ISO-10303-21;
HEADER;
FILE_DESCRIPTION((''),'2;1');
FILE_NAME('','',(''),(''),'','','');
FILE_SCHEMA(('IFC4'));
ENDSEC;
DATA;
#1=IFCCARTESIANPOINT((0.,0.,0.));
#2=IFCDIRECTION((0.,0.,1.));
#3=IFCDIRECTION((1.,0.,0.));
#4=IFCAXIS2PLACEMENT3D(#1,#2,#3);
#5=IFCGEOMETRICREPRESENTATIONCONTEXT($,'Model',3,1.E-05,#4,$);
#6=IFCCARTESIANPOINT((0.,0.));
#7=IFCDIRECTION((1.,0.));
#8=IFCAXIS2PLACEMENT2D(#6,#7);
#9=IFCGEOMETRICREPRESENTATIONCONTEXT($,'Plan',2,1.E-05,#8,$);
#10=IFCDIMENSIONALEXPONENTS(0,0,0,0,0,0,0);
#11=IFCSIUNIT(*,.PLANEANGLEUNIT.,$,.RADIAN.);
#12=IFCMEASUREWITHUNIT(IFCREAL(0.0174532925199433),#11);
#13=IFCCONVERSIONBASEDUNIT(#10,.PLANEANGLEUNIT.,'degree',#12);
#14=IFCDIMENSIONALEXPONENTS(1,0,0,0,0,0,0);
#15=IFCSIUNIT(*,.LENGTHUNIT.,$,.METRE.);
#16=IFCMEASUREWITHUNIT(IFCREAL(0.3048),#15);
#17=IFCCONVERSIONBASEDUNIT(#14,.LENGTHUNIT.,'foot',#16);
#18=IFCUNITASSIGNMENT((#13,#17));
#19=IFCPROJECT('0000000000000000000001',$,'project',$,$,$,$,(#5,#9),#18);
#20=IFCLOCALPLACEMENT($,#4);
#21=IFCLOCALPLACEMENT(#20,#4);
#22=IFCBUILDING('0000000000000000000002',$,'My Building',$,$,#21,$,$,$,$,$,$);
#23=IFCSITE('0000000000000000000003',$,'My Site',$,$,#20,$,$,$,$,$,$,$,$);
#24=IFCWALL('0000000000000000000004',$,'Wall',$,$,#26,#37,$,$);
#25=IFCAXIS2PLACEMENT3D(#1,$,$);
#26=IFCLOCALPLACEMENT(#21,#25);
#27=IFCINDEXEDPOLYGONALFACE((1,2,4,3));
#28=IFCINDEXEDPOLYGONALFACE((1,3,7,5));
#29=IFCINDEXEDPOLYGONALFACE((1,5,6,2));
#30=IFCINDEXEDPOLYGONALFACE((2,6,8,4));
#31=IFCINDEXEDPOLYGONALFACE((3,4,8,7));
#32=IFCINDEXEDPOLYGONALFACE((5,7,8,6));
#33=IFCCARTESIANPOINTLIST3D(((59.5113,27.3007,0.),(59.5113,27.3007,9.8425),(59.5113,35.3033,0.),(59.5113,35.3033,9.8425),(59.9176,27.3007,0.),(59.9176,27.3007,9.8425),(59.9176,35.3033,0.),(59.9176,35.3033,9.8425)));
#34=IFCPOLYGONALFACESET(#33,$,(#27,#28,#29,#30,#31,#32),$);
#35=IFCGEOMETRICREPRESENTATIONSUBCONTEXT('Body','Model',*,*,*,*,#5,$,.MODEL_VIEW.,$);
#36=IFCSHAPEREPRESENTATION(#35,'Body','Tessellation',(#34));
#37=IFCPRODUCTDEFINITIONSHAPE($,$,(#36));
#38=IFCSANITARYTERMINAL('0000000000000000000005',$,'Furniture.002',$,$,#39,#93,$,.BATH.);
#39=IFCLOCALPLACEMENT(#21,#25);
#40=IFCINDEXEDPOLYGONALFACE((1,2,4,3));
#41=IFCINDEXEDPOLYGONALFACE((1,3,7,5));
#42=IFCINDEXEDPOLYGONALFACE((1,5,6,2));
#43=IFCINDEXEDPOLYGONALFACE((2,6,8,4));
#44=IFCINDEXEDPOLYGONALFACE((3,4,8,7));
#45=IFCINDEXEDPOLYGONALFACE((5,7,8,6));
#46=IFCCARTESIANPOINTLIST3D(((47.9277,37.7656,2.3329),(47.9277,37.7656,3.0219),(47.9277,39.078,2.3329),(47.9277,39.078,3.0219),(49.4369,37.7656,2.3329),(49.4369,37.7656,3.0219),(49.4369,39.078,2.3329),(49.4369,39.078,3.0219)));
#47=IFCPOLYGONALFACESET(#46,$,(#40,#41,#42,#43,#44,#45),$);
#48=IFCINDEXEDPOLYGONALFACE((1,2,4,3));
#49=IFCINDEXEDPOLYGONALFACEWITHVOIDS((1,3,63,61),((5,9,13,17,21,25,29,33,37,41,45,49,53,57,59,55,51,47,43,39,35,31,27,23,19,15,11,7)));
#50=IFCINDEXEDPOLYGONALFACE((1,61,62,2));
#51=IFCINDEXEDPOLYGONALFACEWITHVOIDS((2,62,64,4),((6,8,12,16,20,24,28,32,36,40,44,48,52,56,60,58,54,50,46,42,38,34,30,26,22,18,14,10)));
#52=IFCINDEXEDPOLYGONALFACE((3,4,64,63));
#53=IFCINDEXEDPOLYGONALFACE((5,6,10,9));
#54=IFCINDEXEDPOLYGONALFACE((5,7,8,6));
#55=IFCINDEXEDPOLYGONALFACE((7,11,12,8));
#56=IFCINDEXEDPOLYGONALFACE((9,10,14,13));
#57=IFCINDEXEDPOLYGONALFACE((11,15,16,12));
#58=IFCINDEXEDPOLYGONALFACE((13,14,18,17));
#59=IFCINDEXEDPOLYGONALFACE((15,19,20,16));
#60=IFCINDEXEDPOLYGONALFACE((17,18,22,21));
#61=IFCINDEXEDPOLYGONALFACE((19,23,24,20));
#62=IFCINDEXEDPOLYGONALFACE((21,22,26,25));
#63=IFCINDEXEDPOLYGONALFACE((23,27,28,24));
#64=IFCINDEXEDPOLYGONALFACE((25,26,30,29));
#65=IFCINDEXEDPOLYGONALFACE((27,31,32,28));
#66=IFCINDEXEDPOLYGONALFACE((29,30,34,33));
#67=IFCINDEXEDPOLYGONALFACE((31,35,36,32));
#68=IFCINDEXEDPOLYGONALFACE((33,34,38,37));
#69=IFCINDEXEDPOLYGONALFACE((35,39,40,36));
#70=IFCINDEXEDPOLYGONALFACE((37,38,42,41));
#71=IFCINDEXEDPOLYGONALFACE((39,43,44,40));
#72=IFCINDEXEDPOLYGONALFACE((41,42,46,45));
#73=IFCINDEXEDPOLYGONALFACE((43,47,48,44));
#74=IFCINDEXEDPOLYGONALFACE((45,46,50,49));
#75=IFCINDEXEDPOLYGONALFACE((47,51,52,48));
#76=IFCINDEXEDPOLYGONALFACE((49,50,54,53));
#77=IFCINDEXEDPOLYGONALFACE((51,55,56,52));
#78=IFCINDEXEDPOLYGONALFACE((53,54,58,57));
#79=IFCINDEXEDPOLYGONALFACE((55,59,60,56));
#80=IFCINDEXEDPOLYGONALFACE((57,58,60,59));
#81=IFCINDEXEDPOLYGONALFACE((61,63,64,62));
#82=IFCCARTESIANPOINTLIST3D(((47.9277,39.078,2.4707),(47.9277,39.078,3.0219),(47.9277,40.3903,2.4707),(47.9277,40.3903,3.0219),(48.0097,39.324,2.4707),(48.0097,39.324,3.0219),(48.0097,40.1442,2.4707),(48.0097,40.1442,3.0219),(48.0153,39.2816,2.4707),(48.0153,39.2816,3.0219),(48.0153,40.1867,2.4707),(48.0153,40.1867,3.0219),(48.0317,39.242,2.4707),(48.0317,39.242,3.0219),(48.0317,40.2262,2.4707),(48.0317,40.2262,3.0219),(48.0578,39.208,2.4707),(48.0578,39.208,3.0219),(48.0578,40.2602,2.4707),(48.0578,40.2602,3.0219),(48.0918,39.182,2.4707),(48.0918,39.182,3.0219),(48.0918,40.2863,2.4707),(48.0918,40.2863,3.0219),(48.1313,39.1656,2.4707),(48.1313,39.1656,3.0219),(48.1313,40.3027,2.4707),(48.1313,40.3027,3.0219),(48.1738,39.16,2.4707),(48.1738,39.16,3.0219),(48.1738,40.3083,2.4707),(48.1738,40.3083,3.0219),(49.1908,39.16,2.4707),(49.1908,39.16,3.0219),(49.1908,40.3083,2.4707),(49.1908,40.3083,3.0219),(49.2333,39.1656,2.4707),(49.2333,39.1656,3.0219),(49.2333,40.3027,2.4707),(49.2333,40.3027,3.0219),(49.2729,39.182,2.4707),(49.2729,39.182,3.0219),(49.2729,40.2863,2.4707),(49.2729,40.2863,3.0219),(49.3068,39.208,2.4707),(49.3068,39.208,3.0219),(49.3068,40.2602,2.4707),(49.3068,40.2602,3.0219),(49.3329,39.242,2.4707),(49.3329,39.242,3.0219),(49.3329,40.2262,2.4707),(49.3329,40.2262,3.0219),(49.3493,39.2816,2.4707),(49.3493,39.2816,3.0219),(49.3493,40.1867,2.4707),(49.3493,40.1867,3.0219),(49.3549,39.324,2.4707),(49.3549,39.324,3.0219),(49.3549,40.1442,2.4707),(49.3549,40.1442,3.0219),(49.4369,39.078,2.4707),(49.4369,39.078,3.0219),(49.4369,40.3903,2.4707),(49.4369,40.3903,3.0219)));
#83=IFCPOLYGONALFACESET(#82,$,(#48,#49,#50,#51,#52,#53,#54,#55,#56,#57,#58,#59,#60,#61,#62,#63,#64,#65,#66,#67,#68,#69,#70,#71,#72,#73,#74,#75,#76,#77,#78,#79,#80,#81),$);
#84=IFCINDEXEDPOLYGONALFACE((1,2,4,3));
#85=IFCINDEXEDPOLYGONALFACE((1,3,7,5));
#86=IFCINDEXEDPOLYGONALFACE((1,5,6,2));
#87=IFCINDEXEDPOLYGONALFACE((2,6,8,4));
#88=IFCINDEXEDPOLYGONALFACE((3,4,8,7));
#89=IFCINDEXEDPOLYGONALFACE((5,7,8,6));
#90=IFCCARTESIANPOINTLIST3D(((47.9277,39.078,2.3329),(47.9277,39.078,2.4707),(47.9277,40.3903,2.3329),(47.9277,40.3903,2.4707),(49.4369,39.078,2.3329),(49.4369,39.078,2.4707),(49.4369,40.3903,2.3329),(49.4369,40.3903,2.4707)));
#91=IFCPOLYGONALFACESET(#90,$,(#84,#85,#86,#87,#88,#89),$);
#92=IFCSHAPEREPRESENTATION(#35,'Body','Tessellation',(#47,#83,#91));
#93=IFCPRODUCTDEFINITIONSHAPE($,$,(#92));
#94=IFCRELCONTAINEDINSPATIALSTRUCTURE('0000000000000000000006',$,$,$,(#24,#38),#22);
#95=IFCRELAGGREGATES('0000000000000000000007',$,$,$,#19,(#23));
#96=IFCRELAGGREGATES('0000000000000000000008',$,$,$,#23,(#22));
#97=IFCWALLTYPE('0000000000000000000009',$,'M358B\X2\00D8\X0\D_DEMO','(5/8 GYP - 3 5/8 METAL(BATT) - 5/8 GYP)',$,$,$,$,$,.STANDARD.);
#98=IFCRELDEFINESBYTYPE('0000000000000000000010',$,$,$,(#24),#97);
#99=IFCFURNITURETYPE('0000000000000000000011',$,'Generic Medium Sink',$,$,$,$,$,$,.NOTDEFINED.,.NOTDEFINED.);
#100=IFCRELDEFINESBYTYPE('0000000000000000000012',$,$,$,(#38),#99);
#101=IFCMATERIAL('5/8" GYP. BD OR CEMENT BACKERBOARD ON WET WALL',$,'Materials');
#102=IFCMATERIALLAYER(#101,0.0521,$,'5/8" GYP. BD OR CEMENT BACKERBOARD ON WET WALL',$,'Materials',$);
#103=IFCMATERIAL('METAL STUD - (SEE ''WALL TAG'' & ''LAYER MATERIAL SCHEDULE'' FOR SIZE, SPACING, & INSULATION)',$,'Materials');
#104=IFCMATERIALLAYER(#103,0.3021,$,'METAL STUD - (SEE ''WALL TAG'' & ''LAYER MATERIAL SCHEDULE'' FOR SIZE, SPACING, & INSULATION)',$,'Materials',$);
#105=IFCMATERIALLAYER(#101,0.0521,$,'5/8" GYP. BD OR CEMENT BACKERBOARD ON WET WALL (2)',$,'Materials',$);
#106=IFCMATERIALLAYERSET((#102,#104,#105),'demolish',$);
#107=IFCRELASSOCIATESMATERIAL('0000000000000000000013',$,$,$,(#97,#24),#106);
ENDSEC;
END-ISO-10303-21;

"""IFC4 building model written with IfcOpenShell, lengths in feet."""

from ifc_helpers import new_model, entity, si_unit, converted_unit, frame, origin_with_axes, origin_2d_with_axis, place, context, subcontext, project, spatial, line, indexed_curve, outline, extrude, shape, source, transform, mapped, material, layer, layer_set, layer_usage, type_object, type_shapes, element, save


model = new_model("IFC4")

# Units and contexts
model_context = context("Model", 3, precision=1e-05, world=origin_with_axes())
plan_context = context("Plan", 2, precision=1e-05, world=origin_2d_with_axis())
body_context_1 = subcontext(model_context, "Body", "Model", "MODEL_VIEW")
body_context_2 = subcontext(plan_context, "Body", "Plan", "PLAN_VIEW")
ifc_project = project(units=[converted_unit("PLANEANGLEUNIT", "degree", entity("IfcReal", 0.0174532925199433), si_unit("PLANEANGLEUNIT", "RADIAN"), dimensions=[0, 0, 0, 0, 0, 0, 0]), converted_unit("LENGTHUNIT", "foot", entity("IfcReal", 0.3048), si_unit("LENGTHUNIT", "METRE"), dimensions=[1, 0, 0, 0, 0, 0, 0])], contexts=[model_context, plan_context])

# Site, building
site_placement = place(None, origin_with_axes())
site = spatial("IfcSite", under=ifc_project, at=site_placement, Name="My Site")
building_placement = place(site_placement, origin_with_axes())
building = spatial("IfcBuilding", under=site, at=building_placement, Name="My Building")

# Shared definitions
ifc_material_1 = material(Name="5/8\" GYP. BD OR CEMENT BACKERBOARD ON WET WALL", Category="Materials")
ifc_material_2 = material(Name="METAL STUD - (SEE 'WALL TAG' & 'LAYER MATERIAL SCHEDULE' FOR SIZE, SPACING, & INSULATION)", Category="Materials")

# Wall
ifc_layer_1 = layer(ifc_material_1, 0.0521, Name="5/8\" GYP. BD OR CEMENT BACKERBOARD ON WET WALL", Category="Materials")
ifc_layer_2 = layer(ifc_material_2, 0.3021, Name="METAL STUD - (SEE 'WALL TAG' & 'LAYER MATERIAL SCHEDULE' FOR SIZE, SPACING, & INSULATION)", Category="Materials")
ifc_layer_3 = layer(ifc_material_1, 0.0521, Name="5/8\" GYP. BD OR CEMENT BACKERBOARD ON WET WALL (2)", Category="Materials")
ifc_layer_set_1 = layer_set([ifc_layer_1, ifc_layer_2, ifc_layer_3], Name="demolish")
ifc_layer_usage_1 = layer_usage(ifc_layer_set_1, "AXIS2", "POSITIVE", 0.0)
wall_type_1 = type_object("IfcWallType", Name="M358BØD_DEMO", Description="(5/8 GYP - 3 5/8 METAL(BATT) - 5/8 GYP)", PredefinedType="STANDARD", material=ifc_layer_set_1)
wall_1_placement = place(building_placement, frame((59.9176, 27.3007, 0.0), z_axis=(0.0, 0.0, 1.0), x_axis=(0.000001, 1.0, 0.0)))
element("IfcWall", 1, at=wall_1_placement, inside=building, type_object=wall_type_1, material=ifc_layer_usage_1, Name="Wall", context=body_context_1, shape_type="SweptSolid", body=[
    extrude(outline(indexed_curve([(0.0, 0.0), (0.0, 0.4062), (8.0026, 0.4062), (8.0026, 0.0), (0.0, 0.0)], self_intersect=False)), origin_with_axes(), (0.0, 0.0, 1.0), 9.8425),
])

# Sanitary terminal
furniture_type_1 = type_object("IfcFurnitureType", Name="Generic Medium Sink", AssemblyPlace="NOTDEFINED", PredefinedType="NOTDEFINED")
shared_indexed_poly_curve_1 = entity("IfcIndexedPolyCurve", entity("IfcCartesianPointList2D", [[1.3123, 0.0], [2.6247, 0.0], [2.6247, 1.5092], [1.3123, 1.5092]]), [entity("IfcLineIndex", [1, 2]), entity("IfcLineIndex", [2, 3]), entity("IfcLineIndex", [3, 4]), entity("IfcLineIndex", [4, 1])])
shared_shape_1 = source(origin_with_axes(), body_context_1, "Body", "SweptSolid", [
    extrude(outline(indexed_curve([(0.0, 0.0), (1.3123, 0.0), (1.3123, 1.5092), (0.0, 1.5092)], segments=[line(1, 2), line(2, 3), line(3, 4), line(4, 1)])), frame((-1.3123, -1.5092, 0.0), z_axis=(0.0, 0.0, 1.0), x_axis=(1.0, 0.0, 0.0)), (0.0, 0.0, 1.0), 0.689),
    entity("IfcExtrudedAreaSolid", entity("IfcArbitraryProfileDefWithVoids", "AREA", None, shared_indexed_poly_curve_1, [entity("IfcIndexedPolyCurve", entity("IfcCartesianPointList2D", [[1.3944, 0.2461], [1.4424, 0.1301], [1.5584, 0.082], [2.3786, 0.082], [2.4946, 0.1301], [2.5427, 0.2461], [2.5427, 1.2631], [2.4946, 1.3791], [2.3786, 1.4272], [1.5584, 1.4272], [1.4424, 1.3791], [1.3944, 1.2631]]), [entity("IfcLineIndex", [12, 1]), entity("IfcArcIndex", [1, 2, 3]), entity("IfcLineIndex", [3, 4]), entity("IfcArcIndex", [4, 5, 6]), entity("IfcLineIndex", [6, 7]), entity("IfcArcIndex", [7, 8, 9]), entity("IfcLineIndex", [9, 10]), entity("IfcArcIndex", [10, 11, 12]), entity("IfcLineIndex", [1, 12])])]), entity("IfcAxis2Placement3D", entity("IfcCartesianPoint", [-1.3123, -1.5092, 0.1378]), entity("IfcDirection", [0.0, 0.0, 1.0]), entity("IfcDirection", [1.0, 0.0, 0.0])), entity("IfcDirection", [0.0, 0.0, 1.0]), 0.5512),
    entity("IfcExtrudedAreaSolid", entity("IfcArbitraryClosedProfileDef", "AREA", None, shared_indexed_poly_curve_1), entity("IfcAxis2Placement3D", entity("IfcCartesianPoint", [-1.3123, -1.5092, 0.0]), entity("IfcDirection", [0.0, 0.0, 1.0]), entity("IfcDirection", [1.0, 0.0, 0.0])), entity("IfcDirection", [0.0, 0.0, 1.0]), 0.1378),
])
shared_shape_2 = source(origin_with_axes(), body_context_2, "Body", "Curve2D", [
    entity("IfcIndexedPolyCurve", entity("IfcCartesianPointList2D", [[-1.3123, -1.5092], [1.3123, -1.5092], [1.3123, 0.0], [-1.3123, 0.0]]), [entity("IfcLineIndex", [1, 2]), entity("IfcLineIndex", [2, 3]), entity("IfcLineIndex", [3, 4]), entity("IfcLineIndex", [4, 1])]),
    entity("IfcIndexedPolyCurve", entity("IfcCartesianPointList2D", [[0.082, -1.2631], [0.1301, -1.3791], [0.2461, -1.4272], [1.0663, -1.4272], [1.1823, -1.3791], [1.2303, -1.2631], [1.2303, -0.2461], [1.1823, -0.1301], [1.0663, -0.082], [0.2461, -0.082], [0.1301, -0.1301], [0.082, -0.2461]]), [entity("IfcLineIndex", [12, 1]), entity("IfcArcIndex", [1, 2, 3]), entity("IfcLineIndex", [3, 4]), entity("IfcArcIndex", [4, 5, 6]), entity("IfcLineIndex", [6, 7]), entity("IfcArcIndex", [7, 8, 9]), entity("IfcLineIndex", [9, 10]), entity("IfcArcIndex", [10, 11, 12]), entity("IfcLineIndex", [1, 12])]),
    entity("IfcCircle", entity("IfcAxis2Placement2D", entity("IfcCartesianPoint", [0.6562, -0.4101])), 0.082),
    entity("IfcIndexedPolyCurve", entity("IfcCartesianPointList2D", [[0.6562, -0.041], [0.6562, -0.4347]]), [entity("IfcLineIndex", [1, 2])]),
])
type_shapes(furniture_type_1, [shared_shape_1, shared_shape_2])
sanitary_terminal_1_placement = place(building_placement, frame((47.9277, 39.078, 2.3329), z_axis=(0.0, 0.0, 1.0), x_axis=(0.0, 1.0, 0.0)))
element("IfcSanitaryTerminal", 2, at=sanitary_terminal_1_placement, inside=building, type_object=furniture_type_1, Name="Furniture.002", PredefinedType="BATH", shapes=[
    shape(body_context_1, "Body", "MappedRepresentation", [mapped(shared_shape_1, transform((0.0, 0.0, 0.0), x_axis=(1.0, 0.0, 0.0), y_axis=(0.0, 1.0, 0.0), z_axis=(0.0, 0.0, 1.0), scale=1.0))]),
    shape(body_context_2, "Body", "MappedRepresentation", [mapped(shared_shape_2, transform((0.0, 0.0, 0.0), x_axis=(1.0, 0.0, 0.0), y_axis=(0.0, 1.0, 0.0), z_axis=(0.0, 0.0, 1.0), scale=1.0))]),
])

save(model, "model.ifc")
